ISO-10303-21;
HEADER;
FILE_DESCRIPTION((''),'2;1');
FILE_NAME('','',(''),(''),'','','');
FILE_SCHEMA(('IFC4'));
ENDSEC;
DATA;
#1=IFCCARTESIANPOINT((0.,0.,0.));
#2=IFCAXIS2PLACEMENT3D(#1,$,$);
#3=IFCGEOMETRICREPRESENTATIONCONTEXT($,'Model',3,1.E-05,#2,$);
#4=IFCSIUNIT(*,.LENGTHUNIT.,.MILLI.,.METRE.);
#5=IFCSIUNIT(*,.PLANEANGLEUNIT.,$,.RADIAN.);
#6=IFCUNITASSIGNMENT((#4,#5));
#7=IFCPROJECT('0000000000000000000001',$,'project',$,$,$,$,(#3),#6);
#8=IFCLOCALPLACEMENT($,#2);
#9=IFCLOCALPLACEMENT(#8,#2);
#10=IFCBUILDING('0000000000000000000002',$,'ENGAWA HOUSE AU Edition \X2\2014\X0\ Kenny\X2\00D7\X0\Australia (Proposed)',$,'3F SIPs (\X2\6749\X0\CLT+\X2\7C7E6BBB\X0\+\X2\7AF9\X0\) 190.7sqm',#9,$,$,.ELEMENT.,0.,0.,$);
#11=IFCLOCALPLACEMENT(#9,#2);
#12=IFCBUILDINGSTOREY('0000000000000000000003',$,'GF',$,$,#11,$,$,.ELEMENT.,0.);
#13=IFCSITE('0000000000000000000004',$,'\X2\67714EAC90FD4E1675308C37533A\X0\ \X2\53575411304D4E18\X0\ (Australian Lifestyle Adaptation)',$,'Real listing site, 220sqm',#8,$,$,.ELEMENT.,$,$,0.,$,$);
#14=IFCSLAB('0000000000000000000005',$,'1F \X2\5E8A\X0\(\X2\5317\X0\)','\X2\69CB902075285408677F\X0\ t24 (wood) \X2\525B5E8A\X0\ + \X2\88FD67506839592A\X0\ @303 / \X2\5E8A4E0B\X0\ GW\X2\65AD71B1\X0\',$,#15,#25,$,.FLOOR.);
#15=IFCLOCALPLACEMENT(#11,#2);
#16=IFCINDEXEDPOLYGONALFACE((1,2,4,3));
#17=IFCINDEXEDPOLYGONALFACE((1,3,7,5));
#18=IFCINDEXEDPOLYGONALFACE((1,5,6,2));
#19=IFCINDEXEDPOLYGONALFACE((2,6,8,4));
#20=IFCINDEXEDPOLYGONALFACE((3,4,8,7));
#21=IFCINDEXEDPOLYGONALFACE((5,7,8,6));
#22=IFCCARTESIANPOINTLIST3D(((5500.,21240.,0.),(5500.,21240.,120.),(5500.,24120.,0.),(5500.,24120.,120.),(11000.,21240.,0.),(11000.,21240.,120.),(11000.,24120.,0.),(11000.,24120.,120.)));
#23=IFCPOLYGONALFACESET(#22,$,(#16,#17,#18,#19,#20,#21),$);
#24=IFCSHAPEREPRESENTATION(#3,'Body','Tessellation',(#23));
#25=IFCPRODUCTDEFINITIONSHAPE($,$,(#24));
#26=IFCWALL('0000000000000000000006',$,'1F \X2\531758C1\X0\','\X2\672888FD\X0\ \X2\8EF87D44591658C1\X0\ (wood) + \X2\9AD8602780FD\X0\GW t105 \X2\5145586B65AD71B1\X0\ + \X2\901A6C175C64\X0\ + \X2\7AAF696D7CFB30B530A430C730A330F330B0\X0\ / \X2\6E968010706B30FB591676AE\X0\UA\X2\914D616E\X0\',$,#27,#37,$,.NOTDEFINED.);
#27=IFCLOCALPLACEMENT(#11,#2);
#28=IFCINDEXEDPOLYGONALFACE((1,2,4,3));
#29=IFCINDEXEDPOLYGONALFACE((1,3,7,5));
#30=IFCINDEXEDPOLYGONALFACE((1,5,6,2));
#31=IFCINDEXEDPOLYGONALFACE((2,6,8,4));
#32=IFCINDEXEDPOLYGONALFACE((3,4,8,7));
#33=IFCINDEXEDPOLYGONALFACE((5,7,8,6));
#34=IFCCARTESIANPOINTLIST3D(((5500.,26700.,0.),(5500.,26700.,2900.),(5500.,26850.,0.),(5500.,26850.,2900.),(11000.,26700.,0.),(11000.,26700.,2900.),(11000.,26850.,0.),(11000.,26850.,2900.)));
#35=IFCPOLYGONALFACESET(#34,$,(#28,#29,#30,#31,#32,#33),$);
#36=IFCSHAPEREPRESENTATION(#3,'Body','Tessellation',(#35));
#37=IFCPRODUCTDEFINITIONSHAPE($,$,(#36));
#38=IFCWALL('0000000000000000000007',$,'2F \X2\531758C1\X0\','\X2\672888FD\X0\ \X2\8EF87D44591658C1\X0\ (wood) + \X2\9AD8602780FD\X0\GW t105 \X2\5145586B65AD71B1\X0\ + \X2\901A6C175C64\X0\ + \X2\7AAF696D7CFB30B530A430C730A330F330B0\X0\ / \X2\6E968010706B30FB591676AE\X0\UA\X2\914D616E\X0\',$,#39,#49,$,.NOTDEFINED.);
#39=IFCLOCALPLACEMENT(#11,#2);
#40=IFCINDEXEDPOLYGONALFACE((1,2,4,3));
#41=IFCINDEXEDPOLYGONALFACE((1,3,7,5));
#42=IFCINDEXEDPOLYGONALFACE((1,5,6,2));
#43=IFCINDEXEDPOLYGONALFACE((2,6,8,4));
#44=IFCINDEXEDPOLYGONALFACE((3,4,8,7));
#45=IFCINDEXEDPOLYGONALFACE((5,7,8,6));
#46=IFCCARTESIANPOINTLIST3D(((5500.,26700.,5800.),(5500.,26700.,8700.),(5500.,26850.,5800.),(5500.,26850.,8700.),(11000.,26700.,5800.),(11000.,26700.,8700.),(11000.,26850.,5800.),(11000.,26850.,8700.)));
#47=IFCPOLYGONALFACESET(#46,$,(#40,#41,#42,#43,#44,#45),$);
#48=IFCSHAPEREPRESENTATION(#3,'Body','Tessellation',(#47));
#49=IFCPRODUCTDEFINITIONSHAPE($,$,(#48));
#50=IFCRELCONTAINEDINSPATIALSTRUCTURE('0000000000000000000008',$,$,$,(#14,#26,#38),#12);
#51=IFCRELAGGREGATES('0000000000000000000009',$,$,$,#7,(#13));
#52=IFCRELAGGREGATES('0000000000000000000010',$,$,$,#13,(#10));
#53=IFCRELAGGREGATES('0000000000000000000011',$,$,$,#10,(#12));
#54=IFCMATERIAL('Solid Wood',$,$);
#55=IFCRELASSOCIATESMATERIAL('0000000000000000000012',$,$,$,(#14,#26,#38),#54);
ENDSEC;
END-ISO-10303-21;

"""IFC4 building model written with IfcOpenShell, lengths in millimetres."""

from ifc_helpers import new_model, si_unit, frame, frame_2d, origin, place, context, project, spatial, rectangle, extrude, material, element, save


model = new_model("IFC4")

# Units and contexts
model_context = context("Model", 3, precision=1e-05, world=origin())
ifc_project = project(units=[si_unit("LENGTHUNIT", "METRE", prefix="MILLI"), si_unit("PLANEANGLEUNIT", "RADIAN")], contexts=[model_context])

# Site, building, storey
site_placement = place(None, origin())
site = spatial("IfcSite", under=ifc_project, at=site_placement, Name="東京都世田谷区 南向き丘 (Australian Lifestyle Adaptation)", ObjectType="Real listing site, 220sqm", CompositionType="ELEMENT", RefElevation=0.0)
building_placement = place(site_placement, origin())
building = spatial("IfcBuilding", under=site, at=building_placement, Name="ENGAWA HOUSE AU Edition — Kenny×Australia (Proposed)", ObjectType="3F SIPs (杉CLT+籾殻+竹) 190.7sqm", CompositionType="ELEMENT", ElevationOfRefHeight=0.0, ElevationOfTerrain=0.0)
storey_placement = place(building_placement, origin())
storey = spatial("IfcBuildingStorey", under=building, at=storey_placement, Name="GF", CompositionType="ELEMENT", Elevation=0.0)

# Slab
ifc_material_1 = material(Name="Solid Wood")
slab_1_placement = place(storey_placement, frame((2750.0, 10620.0, 0.0)))
element("IfcSlab", 1, at=slab_1_placement, inside=storey, material=ifc_material_1, Name="1F 床(北)", Description="構造用合板 t24 (wood) 剛床 + 製材根太 @303 / 床下 GW断熱", PredefinedType="FLOOR", context=model_context, shape_type="SweptSolid", body=[
    extrude(rectangle(XDim=5500.0, YDim=2880.0, at=frame_2d((2750.0, 1440.0))), frame((2750.0, 10620.0, 0.0)), (0.0, 0.0, 1.0), 120.0),
])

# Wall
wall_1_placement = place(storey_placement, frame((2750.0, 13350.0, 0.0)))
element("IfcWall", 2, at=wall_1_placement, inside=storey, material=ifc_material_1, Name="1F 北壁", Description="木製 軸組外壁 (wood) + 高性能GW t105 充填断熱 + 通気層 + 窯業系サイディング / 準耐火・外皮UA配慮", PredefinedType="NOTDEFINED", context=model_context, shape_type="SweptSolid", body=[
    extrude(rectangle(XDim=5500.0, YDim=150.0, at=frame_2d((2750.0, 75.0))), frame((2750.0, 13350.0, 0.0)), (0.0, 0.0, 1.0), 2900.0),
])

# Wall
wall_2_placement = place(storey_placement, frame((2750.0, 13350.0, 2900.0)))
element("IfcWall", 3, at=wall_2_placement, inside=storey, material=ifc_material_1, Name="2F 北壁", Description="木製 軸組外壁 (wood) + 高性能GW t105 充填断熱 + 通気層 + 窯業系サイディング / 準耐火・外皮UA配慮", PredefinedType="NOTDEFINED", context=model_context, shape_type="SweptSolid", body=[
    extrude(rectangle(XDim=5500.0, YDim=150.0, at=frame_2d((2750.0, 75.0))), frame((2750.0, 13350.0, 2900.0)), (0.0, 0.0, 1.0), 2900.0),
])

save(model, "model.ifc")
